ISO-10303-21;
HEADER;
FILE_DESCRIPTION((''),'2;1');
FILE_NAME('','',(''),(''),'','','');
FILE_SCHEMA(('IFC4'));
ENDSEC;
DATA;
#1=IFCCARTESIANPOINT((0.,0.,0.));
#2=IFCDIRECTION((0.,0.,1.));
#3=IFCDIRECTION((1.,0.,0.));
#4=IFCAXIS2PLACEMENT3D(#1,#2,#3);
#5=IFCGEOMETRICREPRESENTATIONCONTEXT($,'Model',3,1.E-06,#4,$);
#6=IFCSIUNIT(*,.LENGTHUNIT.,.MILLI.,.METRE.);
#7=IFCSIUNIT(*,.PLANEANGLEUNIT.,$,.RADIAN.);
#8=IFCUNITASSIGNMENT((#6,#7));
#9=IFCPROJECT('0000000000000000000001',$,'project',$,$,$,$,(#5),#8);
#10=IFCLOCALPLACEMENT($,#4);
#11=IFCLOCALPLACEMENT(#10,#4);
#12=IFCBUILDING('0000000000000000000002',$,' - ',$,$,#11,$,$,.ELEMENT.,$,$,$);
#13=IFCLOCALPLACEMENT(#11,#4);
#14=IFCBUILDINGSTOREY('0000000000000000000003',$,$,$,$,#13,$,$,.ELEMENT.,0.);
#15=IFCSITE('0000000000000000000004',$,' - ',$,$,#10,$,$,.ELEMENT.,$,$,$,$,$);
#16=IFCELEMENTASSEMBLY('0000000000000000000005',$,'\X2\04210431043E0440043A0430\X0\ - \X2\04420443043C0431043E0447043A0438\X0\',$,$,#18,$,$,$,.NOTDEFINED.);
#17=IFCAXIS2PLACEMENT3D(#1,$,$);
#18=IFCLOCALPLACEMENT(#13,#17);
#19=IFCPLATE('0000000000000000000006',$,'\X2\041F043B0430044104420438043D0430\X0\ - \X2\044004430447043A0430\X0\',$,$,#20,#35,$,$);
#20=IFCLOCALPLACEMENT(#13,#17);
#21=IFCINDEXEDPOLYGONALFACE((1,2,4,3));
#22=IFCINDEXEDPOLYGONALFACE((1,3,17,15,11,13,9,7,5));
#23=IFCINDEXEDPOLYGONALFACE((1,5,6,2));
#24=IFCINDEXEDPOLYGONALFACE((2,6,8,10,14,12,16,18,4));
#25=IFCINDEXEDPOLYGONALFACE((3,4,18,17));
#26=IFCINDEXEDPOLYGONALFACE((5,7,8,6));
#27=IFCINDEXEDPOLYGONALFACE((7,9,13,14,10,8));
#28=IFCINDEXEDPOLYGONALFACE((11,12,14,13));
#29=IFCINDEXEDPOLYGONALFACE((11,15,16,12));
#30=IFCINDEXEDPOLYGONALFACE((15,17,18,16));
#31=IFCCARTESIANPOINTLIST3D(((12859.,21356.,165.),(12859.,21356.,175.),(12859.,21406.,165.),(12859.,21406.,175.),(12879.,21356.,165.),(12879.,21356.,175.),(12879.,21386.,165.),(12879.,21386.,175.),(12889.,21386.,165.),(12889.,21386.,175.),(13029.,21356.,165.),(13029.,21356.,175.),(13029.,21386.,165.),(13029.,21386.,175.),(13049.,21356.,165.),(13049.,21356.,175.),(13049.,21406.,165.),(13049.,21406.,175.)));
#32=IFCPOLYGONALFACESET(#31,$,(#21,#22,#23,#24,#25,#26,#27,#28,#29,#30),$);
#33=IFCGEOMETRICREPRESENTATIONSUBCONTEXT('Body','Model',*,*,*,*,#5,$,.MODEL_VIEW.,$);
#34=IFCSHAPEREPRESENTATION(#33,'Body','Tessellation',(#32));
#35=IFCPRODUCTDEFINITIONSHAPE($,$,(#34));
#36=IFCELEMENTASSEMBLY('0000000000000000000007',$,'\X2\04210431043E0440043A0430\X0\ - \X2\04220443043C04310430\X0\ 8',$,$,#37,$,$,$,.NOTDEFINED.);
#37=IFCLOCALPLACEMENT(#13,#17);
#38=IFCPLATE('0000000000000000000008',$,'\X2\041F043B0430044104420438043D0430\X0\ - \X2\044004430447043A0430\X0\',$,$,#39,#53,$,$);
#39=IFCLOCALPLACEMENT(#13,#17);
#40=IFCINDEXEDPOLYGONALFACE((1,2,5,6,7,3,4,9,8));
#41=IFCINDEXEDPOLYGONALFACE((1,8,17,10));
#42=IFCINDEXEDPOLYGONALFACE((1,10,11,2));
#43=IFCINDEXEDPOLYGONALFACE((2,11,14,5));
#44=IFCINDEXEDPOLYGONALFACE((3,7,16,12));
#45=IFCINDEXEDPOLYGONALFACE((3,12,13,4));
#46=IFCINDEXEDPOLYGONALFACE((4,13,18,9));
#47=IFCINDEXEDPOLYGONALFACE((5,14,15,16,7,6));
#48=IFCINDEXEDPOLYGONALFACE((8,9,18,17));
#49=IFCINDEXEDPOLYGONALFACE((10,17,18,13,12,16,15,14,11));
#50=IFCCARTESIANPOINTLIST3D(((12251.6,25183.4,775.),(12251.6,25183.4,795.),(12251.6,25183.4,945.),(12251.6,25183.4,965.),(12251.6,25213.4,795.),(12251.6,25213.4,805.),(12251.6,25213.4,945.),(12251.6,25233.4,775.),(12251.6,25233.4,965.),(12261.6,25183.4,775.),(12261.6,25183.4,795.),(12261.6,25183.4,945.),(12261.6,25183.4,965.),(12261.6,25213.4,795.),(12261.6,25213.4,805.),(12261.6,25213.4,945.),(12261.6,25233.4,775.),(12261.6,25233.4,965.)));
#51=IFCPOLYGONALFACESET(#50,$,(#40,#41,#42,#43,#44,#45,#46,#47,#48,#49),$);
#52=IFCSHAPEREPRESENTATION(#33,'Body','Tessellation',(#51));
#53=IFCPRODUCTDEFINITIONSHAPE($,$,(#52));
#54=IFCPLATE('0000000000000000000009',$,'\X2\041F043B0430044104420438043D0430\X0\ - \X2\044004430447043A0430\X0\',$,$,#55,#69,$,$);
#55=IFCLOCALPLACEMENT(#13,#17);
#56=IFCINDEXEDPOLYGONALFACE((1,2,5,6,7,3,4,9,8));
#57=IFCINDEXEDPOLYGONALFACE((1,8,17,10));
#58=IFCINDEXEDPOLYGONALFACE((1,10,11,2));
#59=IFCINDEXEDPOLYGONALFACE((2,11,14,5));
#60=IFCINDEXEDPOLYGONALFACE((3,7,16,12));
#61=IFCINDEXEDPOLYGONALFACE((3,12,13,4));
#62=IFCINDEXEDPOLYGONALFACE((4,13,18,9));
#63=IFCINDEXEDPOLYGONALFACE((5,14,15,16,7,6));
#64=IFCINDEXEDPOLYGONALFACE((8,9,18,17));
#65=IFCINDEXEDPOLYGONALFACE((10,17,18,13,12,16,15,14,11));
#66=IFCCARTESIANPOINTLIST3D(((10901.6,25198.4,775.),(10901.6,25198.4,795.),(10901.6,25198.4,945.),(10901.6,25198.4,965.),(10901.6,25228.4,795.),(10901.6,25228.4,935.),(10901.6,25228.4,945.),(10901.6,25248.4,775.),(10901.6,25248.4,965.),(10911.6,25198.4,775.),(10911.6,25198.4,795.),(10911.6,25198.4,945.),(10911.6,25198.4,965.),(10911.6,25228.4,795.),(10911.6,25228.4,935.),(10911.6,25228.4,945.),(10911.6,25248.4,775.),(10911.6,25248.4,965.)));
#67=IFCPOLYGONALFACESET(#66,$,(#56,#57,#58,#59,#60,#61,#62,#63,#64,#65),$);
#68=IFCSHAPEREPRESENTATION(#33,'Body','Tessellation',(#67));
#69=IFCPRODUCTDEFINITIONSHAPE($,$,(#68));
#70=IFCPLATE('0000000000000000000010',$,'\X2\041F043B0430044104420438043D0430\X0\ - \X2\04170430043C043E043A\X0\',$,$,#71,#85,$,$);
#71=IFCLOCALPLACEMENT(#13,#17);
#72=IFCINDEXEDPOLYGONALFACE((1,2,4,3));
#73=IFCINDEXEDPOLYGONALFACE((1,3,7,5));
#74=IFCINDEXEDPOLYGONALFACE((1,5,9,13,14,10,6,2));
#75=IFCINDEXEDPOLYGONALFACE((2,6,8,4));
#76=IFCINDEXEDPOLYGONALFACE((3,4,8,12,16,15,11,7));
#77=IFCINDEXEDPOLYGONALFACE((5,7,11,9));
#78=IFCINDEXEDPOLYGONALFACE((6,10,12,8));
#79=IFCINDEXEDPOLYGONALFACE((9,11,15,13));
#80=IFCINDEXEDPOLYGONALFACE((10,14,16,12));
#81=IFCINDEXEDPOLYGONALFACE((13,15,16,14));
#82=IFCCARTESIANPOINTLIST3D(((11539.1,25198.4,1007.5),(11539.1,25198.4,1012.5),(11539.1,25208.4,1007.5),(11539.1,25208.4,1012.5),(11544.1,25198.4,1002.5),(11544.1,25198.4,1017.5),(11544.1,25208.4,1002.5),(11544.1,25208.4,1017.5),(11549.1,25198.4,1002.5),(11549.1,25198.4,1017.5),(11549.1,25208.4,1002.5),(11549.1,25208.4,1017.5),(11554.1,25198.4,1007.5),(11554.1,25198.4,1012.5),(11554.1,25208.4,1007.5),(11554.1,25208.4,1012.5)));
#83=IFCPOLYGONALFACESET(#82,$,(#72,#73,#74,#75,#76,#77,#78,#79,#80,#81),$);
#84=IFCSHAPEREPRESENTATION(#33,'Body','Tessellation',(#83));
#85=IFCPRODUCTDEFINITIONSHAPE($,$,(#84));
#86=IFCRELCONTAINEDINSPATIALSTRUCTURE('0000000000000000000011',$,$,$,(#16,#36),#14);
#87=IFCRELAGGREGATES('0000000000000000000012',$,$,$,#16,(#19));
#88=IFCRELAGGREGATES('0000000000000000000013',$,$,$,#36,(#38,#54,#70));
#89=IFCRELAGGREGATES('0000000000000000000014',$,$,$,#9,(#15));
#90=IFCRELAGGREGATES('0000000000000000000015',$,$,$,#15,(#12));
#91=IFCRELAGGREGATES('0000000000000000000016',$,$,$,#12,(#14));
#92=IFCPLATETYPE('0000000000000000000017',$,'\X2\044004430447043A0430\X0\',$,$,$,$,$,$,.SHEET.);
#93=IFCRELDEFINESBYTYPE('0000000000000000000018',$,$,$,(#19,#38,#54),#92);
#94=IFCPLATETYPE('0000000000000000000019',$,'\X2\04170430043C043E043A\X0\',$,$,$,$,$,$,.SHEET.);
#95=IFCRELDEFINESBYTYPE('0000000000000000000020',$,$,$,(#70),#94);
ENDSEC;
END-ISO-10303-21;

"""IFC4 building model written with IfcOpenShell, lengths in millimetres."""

from ifc_helpers import new_model, si_unit, frame, origin_with_axes, place, context, subcontext, project, spatial, line, indexed_curve, outline, extrude, source, transform, mapped, type_object, element, aggregate, save


model = new_model("IFC4")

# Units and contexts
model_context = context("Model", 3, precision=1e-06, world=origin_with_axes())
body_context = subcontext(model_context, "Body", "Model", "MODEL_VIEW")
ifc_project = project(units=[si_unit("LENGTHUNIT", "METRE", prefix="MILLI"), si_unit("PLANEANGLEUNIT", "RADIAN")], contexts=[model_context])

# Site, building, storey
site_placement = place(None, origin_with_axes())
site = spatial("IfcSite", under=ifc_project, at=site_placement, Name=" - ", CompositionType="ELEMENT")
building_placement = place(site_placement, origin_with_axes())
building = spatial("IfcBuilding", under=site, at=building_placement, Name=" - ", CompositionType="ELEMENT")
storey_placement = place(building_placement, origin_with_axes())
storey = spatial("IfcBuildingStorey", under=building, at=storey_placement, CompositionType="ELEMENT", Elevation=0.0)

# Shared definitions
plate_type_1 = type_object("IfcPlateType", Name="ручка", PredefinedType="SHEET")
shared_shape_1 = source(origin_with_axes(), body_context, "Body", "SweptSolid", [
    extrude(outline(indexed_curve([(-95.0, -25.0), (-75.0, -25.0), (-75.0, 5.0), (-65.0, 5.0), (75.0, 5.0), (75.0, -25.0), (95.0, -25.0), (95.0, 25.0), (-95.0, 25.0)], segments=[line(1, 2), line(2, 3), line(3, 4), line(4, 5), line(5, 6), line(6, 7), line(7, 8), line(8, 9), line(9, 1)])), origin_with_axes(), (0.0, 0.0, 1.0), 10.0),
])

# Element assemblies, plates
assembly_1_placement = place(storey_placement, frame((13154.0, 21356.0, 15.0), z_axis=(0.0, 0.0, 1.0), x_axis=(-1.0, 0.0, 0.0)))
assembly_1 = element("IfcElementAssembly", 1, at=assembly_1_placement, inside=storey, Name="Сборка - тумбочки", PredefinedType="NOTDEFINED")
plate_1_placement = place(assembly_1_placement, frame((200.0, -25.0, 150.0), z_axis=(0.0, 0.0, 1.0), x_axis=(-1.0, 0.0, 0.0)))
plate_1 = element("IfcPlate", 2, at=plate_1_placement, type_object=plate_type_1, Name="Пластина - ручка", context=body_context, shape_type="MappedRepresentation", body=[
    mapped(shared_shape_1, transform((0.0, 0.0, 0.0), x_axis=(1.0, 0.0, 0.0), y_axis=(0.0, 1.0, 0.0), z_axis=(0.0, 0.0, 1.0), scale=1.0)),
])
aggregate(assembly_1, [plate_1])
assembly_2_placement = place(storey_placement, frame((11581.6, 24998.4, 0.0), z_axis=(0.0, 0.0, 1.0), x_axis=(-1.0, 0.0, 0.0)))
assembly_2 = element("IfcElementAssembly", 3, at=assembly_2_placement, inside=storey, Name="Сборка - Тумба 8", PredefinedType="NOTDEFINED")
shared_shape_2 = source(origin_with_axes(), body_context, "Body", "SweptSolid", [
    extrude(outline(indexed_curve([(-95.0, -25.0), (-75.0, -25.0), (-75.0, 5.0), (-65.0, 5.0), (75.0, 5.0), (75.0, -25.0), (95.0, -25.0), (95.0, 25.0), (-95.0, 25.0)], segments=[line(1, 2), line(2, 3), line(3, 4), line(4, 5), line(5, 6), line(6, 7), line(7, 8), line(8, 9), line(9, 1)])), origin_with_axes(), (0.0, 0.0, 1.0), 10.0),
])
plate_2_placement = place(assembly_2_placement, frame((-680.0, -210.0, 870.0), z_axis=(1.0, 0.0, 0.0), x_axis=(0.0, 0.0, 1.0)))
plate_2 = element("IfcPlate", 4, at=plate_2_placement, type_object=plate_type_1, Name="Пластина - ручка", context=body_context, shape_type="MappedRepresentation", body=[
    mapped(shared_shape_2, transform((0.0, 0.0, 0.0), x_axis=(1.0, 0.0, 0.0), y_axis=(0.0, 1.0, 0.0), z_axis=(0.0, 0.0, 1.0), scale=1.0)),
])
shared_shape_3 = source(origin_with_axes(), body_context, "Body", "SweptSolid", [
    extrude(outline(indexed_curve([(-95.0, -25.0), (-75.0, -25.0), (-75.0, 5.0), (-65.0, 5.0), (75.0, 5.0), (75.0, -25.0), (95.0, -25.0), (95.0, 25.0), (-95.0, 25.0)], segments=[line(1, 2), line(2, 3), line(3, 4), line(4, 5), line(5, 6), line(6, 7), line(7, 8), line(8, 9), line(9, 1)])), origin_with_axes(), (0.0, 0.0, 1.0), 10.0),
])
plate_3_placement = place(assembly_2_placement, frame((680.0, -225.0, 870.0), z_axis=(-1.0, 0.0, 0.0), x_axis=(0.0, 0.0, -1.0)))
plate_3 = element("IfcPlate", 5, at=plate_3_placement, type_object=plate_type_1, Name="Пластина - ручка", context=body_context, shape_type="MappedRepresentation", body=[
    mapped(shared_shape_3, transform((0.0, 0.0, 0.0), x_axis=(1.0, 0.0, 0.0), y_axis=(0.0, 1.0, 0.0), z_axis=(0.0, 0.0, 1.0), scale=1.0)),
])
plate_type_2 = type_object("IfcPlateType", Name="Замок", PredefinedType="SHEET")
shared_shape_4 = source(origin_with_axes(), body_context, "Body", "SweptSolid", [
    extrude(outline(indexed_curve([(-2.5, 7.5), (-7.5, 2.5), (-7.5, -2.5), (-2.5, -7.5), (2.5, -7.5), (7.5, -2.5), (7.5, 2.5), (2.5, 7.5)], segments=[line(1, 2), line(2, 3), line(3, 4), line(4, 5), line(5, 6), line(6, 7), line(7, 8), line(8, 1)])), origin_with_axes(), (0.0, 0.0, 1.0), 10.0),
])
plate_4_placement = place(assembly_2_placement, frame((35.0, -200.0, 1010.0), z_axis=(0.0, -1.0, 0.0), x_axis=(0.0, 0.0, 1.0)))
plate_4 = element("IfcPlate", 6, at=plate_4_placement, type_object=plate_type_2, Name="Пластина - Замок", context=body_context, shape_type="MappedRepresentation", body=[
    mapped(shared_shape_4, transform((0.0, 0.0, 0.0), x_axis=(1.0, 0.0, 0.0), y_axis=(0.0, 1.0, 0.0), z_axis=(0.0, 0.0, 1.0), scale=1.0)),
])
aggregate(assembly_2, [plate_2, plate_3, plate_4])

save(model, "model.ifc")
